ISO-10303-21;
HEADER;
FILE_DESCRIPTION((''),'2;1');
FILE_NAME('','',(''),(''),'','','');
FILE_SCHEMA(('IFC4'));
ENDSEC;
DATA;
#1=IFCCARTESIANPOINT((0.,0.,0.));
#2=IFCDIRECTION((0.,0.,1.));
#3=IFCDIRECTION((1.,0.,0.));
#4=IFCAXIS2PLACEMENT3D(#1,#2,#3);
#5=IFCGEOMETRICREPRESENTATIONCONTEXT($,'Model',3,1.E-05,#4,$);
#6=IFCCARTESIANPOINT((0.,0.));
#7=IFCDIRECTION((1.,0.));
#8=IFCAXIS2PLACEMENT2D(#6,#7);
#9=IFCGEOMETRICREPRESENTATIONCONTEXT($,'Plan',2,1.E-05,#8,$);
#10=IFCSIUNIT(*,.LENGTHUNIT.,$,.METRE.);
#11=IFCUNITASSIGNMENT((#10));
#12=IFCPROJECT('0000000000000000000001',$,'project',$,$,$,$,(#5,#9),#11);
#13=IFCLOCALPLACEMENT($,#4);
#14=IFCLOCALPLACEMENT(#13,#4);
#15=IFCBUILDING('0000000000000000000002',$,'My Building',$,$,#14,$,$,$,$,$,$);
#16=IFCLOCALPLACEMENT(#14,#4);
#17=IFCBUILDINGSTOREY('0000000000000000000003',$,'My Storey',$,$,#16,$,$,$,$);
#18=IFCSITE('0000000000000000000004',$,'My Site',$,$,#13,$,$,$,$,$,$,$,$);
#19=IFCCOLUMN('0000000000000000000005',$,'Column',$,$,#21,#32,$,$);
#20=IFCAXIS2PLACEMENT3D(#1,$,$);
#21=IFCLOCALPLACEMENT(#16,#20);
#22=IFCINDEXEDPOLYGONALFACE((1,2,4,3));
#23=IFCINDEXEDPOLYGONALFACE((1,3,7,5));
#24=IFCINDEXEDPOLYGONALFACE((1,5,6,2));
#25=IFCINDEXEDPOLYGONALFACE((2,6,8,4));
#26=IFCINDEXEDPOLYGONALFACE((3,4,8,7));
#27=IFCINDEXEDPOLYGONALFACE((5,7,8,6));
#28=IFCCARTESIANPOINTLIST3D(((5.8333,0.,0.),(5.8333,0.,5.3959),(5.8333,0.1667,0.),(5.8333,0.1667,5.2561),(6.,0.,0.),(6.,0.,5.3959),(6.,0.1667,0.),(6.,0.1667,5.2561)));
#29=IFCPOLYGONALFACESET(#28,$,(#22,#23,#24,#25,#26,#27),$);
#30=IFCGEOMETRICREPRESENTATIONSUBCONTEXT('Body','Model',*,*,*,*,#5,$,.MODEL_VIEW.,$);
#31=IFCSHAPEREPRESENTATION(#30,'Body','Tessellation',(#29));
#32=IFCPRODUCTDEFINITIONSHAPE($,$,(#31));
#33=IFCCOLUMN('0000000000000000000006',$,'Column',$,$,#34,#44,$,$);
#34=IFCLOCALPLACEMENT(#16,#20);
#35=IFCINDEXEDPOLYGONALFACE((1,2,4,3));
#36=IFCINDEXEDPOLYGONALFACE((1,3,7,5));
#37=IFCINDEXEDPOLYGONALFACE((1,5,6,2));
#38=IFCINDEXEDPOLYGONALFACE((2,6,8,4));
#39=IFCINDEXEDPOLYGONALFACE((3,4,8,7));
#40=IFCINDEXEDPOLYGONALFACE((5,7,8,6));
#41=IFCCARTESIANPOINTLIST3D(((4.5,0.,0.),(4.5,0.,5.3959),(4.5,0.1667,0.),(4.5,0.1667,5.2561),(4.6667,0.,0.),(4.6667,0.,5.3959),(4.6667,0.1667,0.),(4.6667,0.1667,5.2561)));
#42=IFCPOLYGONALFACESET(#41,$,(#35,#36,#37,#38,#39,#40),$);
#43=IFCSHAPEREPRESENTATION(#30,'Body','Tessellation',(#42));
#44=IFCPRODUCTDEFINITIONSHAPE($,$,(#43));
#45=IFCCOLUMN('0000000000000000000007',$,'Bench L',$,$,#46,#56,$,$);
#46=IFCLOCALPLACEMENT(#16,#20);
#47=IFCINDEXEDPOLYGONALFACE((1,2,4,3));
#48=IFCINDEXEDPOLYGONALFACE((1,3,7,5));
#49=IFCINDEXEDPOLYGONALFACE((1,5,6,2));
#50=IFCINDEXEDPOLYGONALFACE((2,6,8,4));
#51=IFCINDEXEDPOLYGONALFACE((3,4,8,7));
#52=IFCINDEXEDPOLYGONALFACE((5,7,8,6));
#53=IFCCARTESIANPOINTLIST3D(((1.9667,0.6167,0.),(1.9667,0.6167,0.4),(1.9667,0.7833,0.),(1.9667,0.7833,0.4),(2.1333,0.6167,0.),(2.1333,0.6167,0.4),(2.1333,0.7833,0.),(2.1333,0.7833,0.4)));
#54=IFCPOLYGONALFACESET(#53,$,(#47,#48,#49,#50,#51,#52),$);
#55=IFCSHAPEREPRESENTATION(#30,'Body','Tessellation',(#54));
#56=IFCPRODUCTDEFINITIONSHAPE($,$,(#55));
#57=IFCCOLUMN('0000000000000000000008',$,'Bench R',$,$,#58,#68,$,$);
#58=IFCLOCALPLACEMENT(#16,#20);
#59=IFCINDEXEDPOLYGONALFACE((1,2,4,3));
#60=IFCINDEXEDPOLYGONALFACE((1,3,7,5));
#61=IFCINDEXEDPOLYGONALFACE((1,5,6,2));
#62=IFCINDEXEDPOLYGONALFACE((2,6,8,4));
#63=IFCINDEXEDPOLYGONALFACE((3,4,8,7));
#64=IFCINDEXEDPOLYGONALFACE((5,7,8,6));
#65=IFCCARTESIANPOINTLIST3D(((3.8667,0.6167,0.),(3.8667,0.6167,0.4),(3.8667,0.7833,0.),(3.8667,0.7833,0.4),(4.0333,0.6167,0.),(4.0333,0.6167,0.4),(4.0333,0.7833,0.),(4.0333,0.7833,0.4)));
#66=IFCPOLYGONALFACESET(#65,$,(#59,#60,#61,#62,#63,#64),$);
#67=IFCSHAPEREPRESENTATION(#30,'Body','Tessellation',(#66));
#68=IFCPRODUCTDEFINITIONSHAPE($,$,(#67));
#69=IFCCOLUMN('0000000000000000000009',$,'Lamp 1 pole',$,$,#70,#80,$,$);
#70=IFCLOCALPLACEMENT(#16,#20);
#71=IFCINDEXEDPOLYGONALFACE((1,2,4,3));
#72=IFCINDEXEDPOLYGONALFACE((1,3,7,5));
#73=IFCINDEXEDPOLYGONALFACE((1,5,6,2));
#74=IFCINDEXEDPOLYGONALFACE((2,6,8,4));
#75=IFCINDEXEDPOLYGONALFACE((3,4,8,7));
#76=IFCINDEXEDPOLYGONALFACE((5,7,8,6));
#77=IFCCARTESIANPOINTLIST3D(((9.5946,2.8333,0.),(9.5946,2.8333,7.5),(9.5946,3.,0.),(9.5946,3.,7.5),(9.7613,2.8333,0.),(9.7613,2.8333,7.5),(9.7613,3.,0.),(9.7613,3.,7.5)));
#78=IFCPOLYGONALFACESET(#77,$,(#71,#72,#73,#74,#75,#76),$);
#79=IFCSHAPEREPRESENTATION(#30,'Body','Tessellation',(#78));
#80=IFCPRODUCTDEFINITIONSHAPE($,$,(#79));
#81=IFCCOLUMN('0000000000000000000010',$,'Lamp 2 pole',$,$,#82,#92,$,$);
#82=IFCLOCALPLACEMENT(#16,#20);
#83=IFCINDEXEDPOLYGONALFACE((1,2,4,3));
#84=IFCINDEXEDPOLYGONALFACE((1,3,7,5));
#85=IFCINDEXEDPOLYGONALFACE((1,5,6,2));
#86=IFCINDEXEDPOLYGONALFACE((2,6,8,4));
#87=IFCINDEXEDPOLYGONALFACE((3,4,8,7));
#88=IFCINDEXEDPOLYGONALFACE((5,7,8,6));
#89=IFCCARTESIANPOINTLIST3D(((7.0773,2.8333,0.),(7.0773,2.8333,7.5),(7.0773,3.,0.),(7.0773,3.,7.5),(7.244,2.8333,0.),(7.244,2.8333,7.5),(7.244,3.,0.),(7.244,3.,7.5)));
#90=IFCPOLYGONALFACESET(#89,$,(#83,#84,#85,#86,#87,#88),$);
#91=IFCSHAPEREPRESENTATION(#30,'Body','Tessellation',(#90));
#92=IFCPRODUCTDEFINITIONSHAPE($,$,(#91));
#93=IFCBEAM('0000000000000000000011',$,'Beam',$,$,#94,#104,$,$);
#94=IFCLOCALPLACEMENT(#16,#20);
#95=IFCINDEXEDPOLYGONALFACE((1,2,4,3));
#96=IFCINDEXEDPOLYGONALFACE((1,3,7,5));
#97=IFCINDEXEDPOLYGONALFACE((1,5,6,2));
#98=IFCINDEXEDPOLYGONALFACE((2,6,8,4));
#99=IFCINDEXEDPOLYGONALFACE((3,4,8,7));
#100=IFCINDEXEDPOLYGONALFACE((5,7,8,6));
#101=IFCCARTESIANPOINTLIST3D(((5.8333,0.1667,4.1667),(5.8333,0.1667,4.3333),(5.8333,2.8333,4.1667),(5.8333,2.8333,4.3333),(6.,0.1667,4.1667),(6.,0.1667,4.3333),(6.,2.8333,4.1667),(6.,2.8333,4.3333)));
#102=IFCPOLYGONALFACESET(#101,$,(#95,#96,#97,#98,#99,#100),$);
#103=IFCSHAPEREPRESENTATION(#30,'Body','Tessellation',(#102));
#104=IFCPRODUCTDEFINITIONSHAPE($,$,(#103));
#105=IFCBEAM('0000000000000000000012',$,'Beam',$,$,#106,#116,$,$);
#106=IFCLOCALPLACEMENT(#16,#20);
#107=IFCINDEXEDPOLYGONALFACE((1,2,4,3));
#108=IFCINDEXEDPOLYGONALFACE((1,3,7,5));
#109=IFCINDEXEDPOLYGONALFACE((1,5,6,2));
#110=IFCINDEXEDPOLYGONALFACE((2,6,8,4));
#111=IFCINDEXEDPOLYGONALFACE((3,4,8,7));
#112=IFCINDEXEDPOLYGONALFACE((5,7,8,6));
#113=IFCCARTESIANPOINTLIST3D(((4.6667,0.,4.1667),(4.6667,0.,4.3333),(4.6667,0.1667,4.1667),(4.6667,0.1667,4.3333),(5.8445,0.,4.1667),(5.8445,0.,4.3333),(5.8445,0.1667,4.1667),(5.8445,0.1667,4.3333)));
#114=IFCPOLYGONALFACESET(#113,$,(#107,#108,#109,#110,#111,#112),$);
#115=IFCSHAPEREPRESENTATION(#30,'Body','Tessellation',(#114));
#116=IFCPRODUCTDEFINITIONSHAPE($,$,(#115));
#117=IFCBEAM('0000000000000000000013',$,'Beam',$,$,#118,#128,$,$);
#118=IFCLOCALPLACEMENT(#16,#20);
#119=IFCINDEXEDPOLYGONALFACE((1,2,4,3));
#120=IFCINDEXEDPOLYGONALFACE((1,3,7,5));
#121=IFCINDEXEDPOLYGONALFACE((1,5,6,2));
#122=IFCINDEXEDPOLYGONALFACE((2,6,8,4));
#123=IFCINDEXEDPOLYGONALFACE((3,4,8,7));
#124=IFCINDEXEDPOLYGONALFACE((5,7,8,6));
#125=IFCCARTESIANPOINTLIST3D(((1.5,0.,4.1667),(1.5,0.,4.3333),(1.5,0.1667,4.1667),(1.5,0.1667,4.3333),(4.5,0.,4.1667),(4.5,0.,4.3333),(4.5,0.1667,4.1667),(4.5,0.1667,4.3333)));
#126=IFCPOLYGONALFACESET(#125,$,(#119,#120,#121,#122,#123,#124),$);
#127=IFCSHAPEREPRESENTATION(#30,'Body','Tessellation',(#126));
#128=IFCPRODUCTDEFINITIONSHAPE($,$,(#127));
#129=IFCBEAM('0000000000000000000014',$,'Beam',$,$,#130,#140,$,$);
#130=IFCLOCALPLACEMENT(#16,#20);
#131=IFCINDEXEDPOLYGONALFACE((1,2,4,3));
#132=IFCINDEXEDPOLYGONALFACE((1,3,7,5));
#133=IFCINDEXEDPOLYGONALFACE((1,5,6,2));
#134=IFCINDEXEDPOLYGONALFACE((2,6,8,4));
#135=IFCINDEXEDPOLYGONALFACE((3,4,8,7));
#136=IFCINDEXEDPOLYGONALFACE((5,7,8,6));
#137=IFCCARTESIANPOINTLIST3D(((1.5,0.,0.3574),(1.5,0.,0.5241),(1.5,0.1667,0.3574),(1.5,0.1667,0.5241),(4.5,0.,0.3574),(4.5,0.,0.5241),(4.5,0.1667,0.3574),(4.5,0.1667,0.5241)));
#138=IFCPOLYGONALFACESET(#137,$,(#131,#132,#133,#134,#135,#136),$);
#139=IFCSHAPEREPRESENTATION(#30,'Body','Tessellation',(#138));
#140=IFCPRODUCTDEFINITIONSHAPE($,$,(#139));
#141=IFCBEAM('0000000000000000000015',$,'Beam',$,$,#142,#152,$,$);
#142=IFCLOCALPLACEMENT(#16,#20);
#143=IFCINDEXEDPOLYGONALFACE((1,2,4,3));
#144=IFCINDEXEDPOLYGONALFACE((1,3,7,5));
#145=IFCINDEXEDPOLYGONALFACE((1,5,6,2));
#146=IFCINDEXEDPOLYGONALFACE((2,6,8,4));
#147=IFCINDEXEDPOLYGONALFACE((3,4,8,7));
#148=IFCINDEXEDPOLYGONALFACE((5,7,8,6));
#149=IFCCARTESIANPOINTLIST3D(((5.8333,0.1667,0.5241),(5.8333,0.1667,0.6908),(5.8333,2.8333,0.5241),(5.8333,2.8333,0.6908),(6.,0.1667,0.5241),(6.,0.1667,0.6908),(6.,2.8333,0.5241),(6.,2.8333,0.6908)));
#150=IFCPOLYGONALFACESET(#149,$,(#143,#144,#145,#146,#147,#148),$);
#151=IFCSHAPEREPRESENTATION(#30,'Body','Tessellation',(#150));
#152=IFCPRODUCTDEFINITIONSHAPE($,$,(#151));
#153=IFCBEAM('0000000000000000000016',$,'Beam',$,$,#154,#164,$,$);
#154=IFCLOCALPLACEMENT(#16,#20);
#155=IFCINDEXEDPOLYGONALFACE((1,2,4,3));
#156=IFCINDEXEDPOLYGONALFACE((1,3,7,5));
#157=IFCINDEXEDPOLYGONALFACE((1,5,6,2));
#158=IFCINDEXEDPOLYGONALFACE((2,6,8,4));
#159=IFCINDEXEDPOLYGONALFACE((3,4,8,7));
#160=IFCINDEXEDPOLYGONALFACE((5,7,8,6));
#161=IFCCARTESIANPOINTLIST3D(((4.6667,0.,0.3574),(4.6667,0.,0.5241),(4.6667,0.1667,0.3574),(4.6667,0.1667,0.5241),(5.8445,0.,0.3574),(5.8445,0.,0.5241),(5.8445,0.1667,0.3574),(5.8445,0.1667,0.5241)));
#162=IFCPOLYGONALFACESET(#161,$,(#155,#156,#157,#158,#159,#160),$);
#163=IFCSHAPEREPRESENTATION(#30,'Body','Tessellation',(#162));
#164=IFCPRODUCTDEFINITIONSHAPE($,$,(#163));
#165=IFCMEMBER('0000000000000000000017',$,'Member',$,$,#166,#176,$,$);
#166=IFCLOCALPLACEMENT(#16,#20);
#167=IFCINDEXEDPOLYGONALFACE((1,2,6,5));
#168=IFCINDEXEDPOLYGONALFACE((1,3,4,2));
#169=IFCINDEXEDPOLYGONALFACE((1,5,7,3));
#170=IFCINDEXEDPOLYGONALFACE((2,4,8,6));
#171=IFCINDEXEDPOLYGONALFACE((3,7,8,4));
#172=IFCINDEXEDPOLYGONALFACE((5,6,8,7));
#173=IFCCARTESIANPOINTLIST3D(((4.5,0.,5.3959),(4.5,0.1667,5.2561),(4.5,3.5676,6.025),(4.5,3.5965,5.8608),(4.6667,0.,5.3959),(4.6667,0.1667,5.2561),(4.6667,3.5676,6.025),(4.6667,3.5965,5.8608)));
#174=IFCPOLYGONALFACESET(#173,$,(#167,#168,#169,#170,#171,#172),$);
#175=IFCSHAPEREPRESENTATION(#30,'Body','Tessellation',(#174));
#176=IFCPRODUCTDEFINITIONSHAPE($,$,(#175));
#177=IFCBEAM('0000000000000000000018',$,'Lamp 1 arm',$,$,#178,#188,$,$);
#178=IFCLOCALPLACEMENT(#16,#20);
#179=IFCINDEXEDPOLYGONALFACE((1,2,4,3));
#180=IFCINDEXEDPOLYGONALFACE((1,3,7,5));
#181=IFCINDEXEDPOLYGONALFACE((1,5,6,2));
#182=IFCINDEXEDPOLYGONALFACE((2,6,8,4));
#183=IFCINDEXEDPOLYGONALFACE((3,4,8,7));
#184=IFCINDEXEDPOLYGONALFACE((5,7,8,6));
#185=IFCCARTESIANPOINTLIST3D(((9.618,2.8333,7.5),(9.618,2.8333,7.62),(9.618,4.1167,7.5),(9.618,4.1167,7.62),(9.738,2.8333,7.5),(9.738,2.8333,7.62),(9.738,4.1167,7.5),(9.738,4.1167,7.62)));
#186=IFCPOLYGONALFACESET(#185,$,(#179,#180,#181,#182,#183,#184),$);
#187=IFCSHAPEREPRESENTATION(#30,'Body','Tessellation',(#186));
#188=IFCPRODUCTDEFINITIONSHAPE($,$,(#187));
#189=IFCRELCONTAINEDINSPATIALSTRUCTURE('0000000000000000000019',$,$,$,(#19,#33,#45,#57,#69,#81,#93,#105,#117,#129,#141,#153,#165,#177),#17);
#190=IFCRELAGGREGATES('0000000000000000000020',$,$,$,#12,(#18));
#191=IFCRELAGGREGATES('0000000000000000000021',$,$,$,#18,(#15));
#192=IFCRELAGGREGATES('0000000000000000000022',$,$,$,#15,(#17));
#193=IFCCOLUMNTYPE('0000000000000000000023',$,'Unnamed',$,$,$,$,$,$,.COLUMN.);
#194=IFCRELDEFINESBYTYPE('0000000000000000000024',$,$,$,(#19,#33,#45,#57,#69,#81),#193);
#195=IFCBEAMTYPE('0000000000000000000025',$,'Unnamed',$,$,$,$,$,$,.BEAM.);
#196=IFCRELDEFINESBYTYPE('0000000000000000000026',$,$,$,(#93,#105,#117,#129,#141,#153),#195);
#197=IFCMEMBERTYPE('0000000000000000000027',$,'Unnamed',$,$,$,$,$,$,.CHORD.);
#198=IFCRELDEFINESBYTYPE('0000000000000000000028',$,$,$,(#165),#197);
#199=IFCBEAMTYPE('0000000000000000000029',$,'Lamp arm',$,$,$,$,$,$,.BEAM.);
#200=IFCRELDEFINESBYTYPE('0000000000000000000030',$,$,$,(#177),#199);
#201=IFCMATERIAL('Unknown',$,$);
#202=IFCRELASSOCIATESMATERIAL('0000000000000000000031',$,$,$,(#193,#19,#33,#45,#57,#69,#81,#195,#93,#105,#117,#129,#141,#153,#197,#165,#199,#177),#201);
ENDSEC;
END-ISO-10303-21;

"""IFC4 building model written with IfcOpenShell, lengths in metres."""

from ifc_helpers import new_model, si_unit, frame, origin_with_axes, origin_2d_with_axis, place, context, subcontext, project, spatial, rectangle, extrude, clip, halfspace, material, material_profile, profile_set, profile_usage, type_object, element, save


model = new_model("IFC4")

# Units and contexts
model_context = context("Model", 3, precision=1e-05, world=origin_with_axes())
plan_context = context("Plan", 2, precision=1e-05, world=origin_2d_with_axis())
body_context = subcontext(model_context, "Body", "Model", "MODEL_VIEW")
ifc_project = project(units=[si_unit("LENGTHUNIT", "METRE")], contexts=[model_context, plan_context])

# Site, building, storey
site_placement = place(None, origin_with_axes())
site = spatial("IfcSite", under=ifc_project, at=site_placement, Name="My Site")
building_placement = place(site_placement, origin_with_axes())
building = spatial("IfcBuilding", under=site, at=building_placement, Name="My Building")
storey_placement = place(building_placement, origin_with_axes())
storey = spatial("IfcBuildingStorey", under=building, at=storey_placement, Name="My Storey")

# Columns
ifc_material = material(Name="Unknown")
ifc_material_profile_1 = material_profile(ifc_material, rectangle(XDim=0.1667, YDim=0.1667))
ifc_profile_set_1 = profile_set([ifc_material_profile_1])
column_type = type_object("IfcColumnType", Name="Unnamed", PredefinedType="COLUMN", material=ifc_profile_set_1)
ifc_profile_usage_1 = profile_usage(ifc_profile_set_1, cardinal=5)
column_1_placement = place(storey_placement, frame((5.9167, 0.0833, 0.0), z_axis=(0.0, 0.0, 1.0), x_axis=(1.0, 0.0, 0.0)))
element("IfcColumn", 1, at=column_1_placement, inside=storey, type_object=column_type, material=ifc_profile_usage_1, Name="Column", context=body_context, shape_type="Clipping", body=[
    clip(extrude(rectangle(XDim=0.1667, YDim=0.1667), origin_with_axes(), (0.0, 0.0, 1.0), 5.5773), halfspace(frame((-5.9167, -0.0833, 5.3959), z_axis=(0.0, 0.642787, 0.766045), x_axis=(1.0, 0.0, 0.0)), False)),
])
ifc_profile_usage_2 = profile_usage(ifc_profile_set_1, cardinal=5)
column_2_placement = place(storey_placement, frame((4.5833, 0.0833, 0.0), z_axis=(0.0, 0.0, 1.0), x_axis=(1.0, 0.0, 0.0)))
element("IfcColumn", 2, at=column_2_placement, inside=storey, type_object=column_type, material=ifc_profile_usage_2, Name="Column", context=body_context, shape_type="Clipping", body=[
    clip(extrude(rectangle(XDim=0.1667, YDim=0.1667), origin_with_axes(), (0.0, 0.0, 1.0), 5.5773), halfspace(frame((-4.5833, -0.0833, 5.3959), z_axis=(0.0, 0.642786, 0.766046), x_axis=(1.0, 0.0, 0.0)), False)),
])
ifc_profile_usage_3 = profile_usage(ifc_profile_set_1, cardinal=5)
column_3_placement = place(storey_placement, frame((2.05, 0.7, 0.0), z_axis=(0.0, 0.0, 1.0), x_axis=(1.0, 0.0, 0.0)))
element("IfcColumn", 3, at=column_3_placement, inside=storey, type_object=column_type, material=ifc_profile_usage_3, Name="Bench L", context=body_context, shape_type="SweptSolid", body=[
    extrude(rectangle(XDim=0.1667, YDim=0.1667), origin_with_axes(), (0.0, 0.0, 1.0), 0.4),
])
ifc_profile_usage_4 = profile_usage(ifc_profile_set_1, cardinal=5)
column_4_placement = place(storey_placement, frame((3.95, 0.7, 0.0), z_axis=(0.0, 0.0, 1.0), x_axis=(1.0, 0.0, 0.0)))
element("IfcColumn", 4, at=column_4_placement, inside=storey, type_object=column_type, material=ifc_profile_usage_4, Name="Bench R", context=body_context, shape_type="SweptSolid", body=[
    extrude(rectangle(XDim=0.1667, YDim=0.1667), origin_with_axes(), (0.0, 0.0, 1.0), 0.4),
])
ifc_profile_usage_5 = profile_usage(ifc_profile_set_1, cardinal=5)
column_5_placement = place(storey_placement, frame((9.678, 2.9167, 0.0), z_axis=(0.0, 0.0, 1.0), x_axis=(1.0, 0.0, 0.0)))
element("IfcColumn", 5, at=column_5_placement, inside=storey, type_object=column_type, material=ifc_profile_usage_5, Name="Lamp 1 pole", context=body_context, shape_type="SweptSolid", body=[
    extrude(rectangle(XDim=0.1667, YDim=0.1667), origin_with_axes(), (0.0, 0.0, 1.0), 7.5),
])
ifc_profile_usage_6 = profile_usage(ifc_profile_set_1, cardinal=5)
column_6_placement = place(storey_placement, frame((7.1606, 2.9167, 0.0), z_axis=(0.0, 0.0, 1.0), x_axis=(1.0, 0.0, 0.0)))
element("IfcColumn", 6, at=column_6_placement, inside=storey, type_object=column_type, material=ifc_profile_usage_6, Name="Lamp 2 pole", context=body_context, shape_type="SweptSolid", body=[
    extrude(rectangle(XDim=0.1667, YDim=0.1667), origin_with_axes(), (0.0, 0.0, 1.0), 7.5),
])

# Beams
ifc_material_profile_2 = material_profile(ifc_material, rectangle(XDim=0.1667, YDim=0.1667))
ifc_profile_set_2 = profile_set([ifc_material_profile_2])
ifc_profile_usage_7 = profile_usage(ifc_profile_set_2, cardinal=5)
beam_type_1 = type_object("IfcBeamType", Name="Unnamed", PredefinedType="BEAM", material=ifc_profile_set_2)
beam_1_placement = place(storey_placement, frame((5.9167, 2.8333, 4.25), z_axis=(0.0, -1.0, 0.0), x_axis=(1.0, 0.0, 0.0)))
element("IfcBeam", 7, at=beam_1_placement, inside=storey, type_object=beam_type_1, material=ifc_profile_usage_7, Name="Beam", context=body_context, shape_type="SweptSolid", body=[
    extrude(rectangle(XDim=0.1667, YDim=0.1667), origin_with_axes(), (0.0, 0.0, 1.0), 2.6667),
])
ifc_profile_usage_8 = profile_usage(ifc_profile_set_2, cardinal=5)
beam_2_placement = place(storey_placement, frame((5.8445, 0.0833, 4.25), z_axis=(-1.0, -0.000001, 0.0), x_axis=(0.000001, -1.0, 0.0)))
element("IfcBeam", 8, at=beam_2_placement, inside=storey, type_object=beam_type_1, material=ifc_profile_usage_8, Name="Beam", context=body_context, shape_type="SweptSolid", body=[
    extrude(rectangle(XDim=0.1667, YDim=0.1667), origin_with_axes(), (0.0, 0.0, 1.0), 1.1778),
])
ifc_profile_usage_9 = profile_usage(ifc_profile_set_2, cardinal=5)
beam_3_placement = place(storey_placement, frame((4.5, 0.0833, 4.25), z_axis=(-1.0, -0.000001, 0.000001), x_axis=(0.000001, -1.0, 0.0)))
element("IfcBeam", 9, at=beam_3_placement, inside=storey, type_object=beam_type_1, material=ifc_profile_usage_9, Name="Beam", context=body_context, shape_type="SweptSolid", body=[
    extrude(rectangle(XDim=0.1667, YDim=0.1667), origin_with_axes(), (0.0, 0.0, 1.0), 3.0),
])
ifc_profile_usage_10 = profile_usage(ifc_profile_set_2, cardinal=5)
beam_4_placement = place(storey_placement, frame((4.5, 0.0833, 0.4408), z_axis=(-1.0, -0.000001, 0.000001), x_axis=(0.000001, -1.0, 0.0)))
element("IfcBeam", 10, at=beam_4_placement, inside=storey, type_object=beam_type_1, material=ifc_profile_usage_10, Name="Beam", context=body_context, shape_type="SweptSolid", body=[
    extrude(rectangle(XDim=0.1667, YDim=0.1667), origin_with_axes(), (0.0, 0.0, 1.0), 3.0),
])
ifc_profile_usage_11 = profile_usage(ifc_profile_set_2, cardinal=5)
beam_5_placement = place(storey_placement, frame((5.9167, 2.8333, 0.6074), z_axis=(0.0, -1.0, 0.0), x_axis=(1.0, 0.0, 0.0)))
element("IfcBeam", 11, at=beam_5_placement, inside=storey, type_object=beam_type_1, material=ifc_profile_usage_11, Name="Beam", context=body_context, shape_type="SweptSolid", body=[
    extrude(rectangle(XDim=0.1667, YDim=0.1667), origin_with_axes(), (0.0, 0.0, 1.0), 2.6667),
])
ifc_profile_usage_12 = profile_usage(ifc_profile_set_2, cardinal=5)
beam_6_placement = place(storey_placement, frame((5.8445, 0.0833, 0.4408), z_axis=(-1.0, -0.000001, 0.0), x_axis=(0.000001, -1.0, 0.0)))
element("IfcBeam", 12, at=beam_6_placement, inside=storey, type_object=beam_type_1, material=ifc_profile_usage_12, Name="Beam", context=body_context, shape_type="SweptSolid", body=[
    extrude(rectangle(XDim=0.1667, YDim=0.1667), origin_with_axes(), (0.0, 0.0, 1.0), 1.1778),
])

# Member
ifc_material_profile_3 = material_profile(ifc_material, rectangle(XDim=0.1667, YDim=0.1667))
ifc_profile_set_3 = profile_set([ifc_material_profile_3])
ifc_profile_usage_13 = profile_usage(ifc_profile_set_3, cardinal=5)
member_type = type_object("IfcMemberType", Name="Unnamed", PredefinedType="CHORD", material=ifc_profile_set_3)
member_1_placement = place(storey_placement, frame((4.5833, -0.1641, 5.2823), z_axis=(0.0, 0.984808, 0.173648), x_axis=(-1.0, 0.0, 0.0)))
element("IfcMember", 13, at=member_1_placement, inside=storey, type_object=member_type, material=ifc_profile_usage_13, Name="Member", context=body_context, shape_type="Clipping", body=[
    clip(extrude(rectangle(XDim=0.1667, YDim=0.1667), origin_with_axes(), (0.0, 0.0, 1.0), 3.8039), halfspace(frame((4.5833, 0.0833, 0.1814), z_axis=(0.0, -0.642788, -0.766045), x_axis=(-1.0, 0.0, 0.0)), False)),
])

# Beam
ifc_material_profile_4 = material_profile(ifc_material, rectangle(XDim=0.12, YDim=0.12))
ifc_profile_set_4 = profile_set([ifc_material_profile_4])
ifc_profile_usage_14 = profile_usage(ifc_profile_set_4, cardinal=5)
beam_type_2 = type_object("IfcBeamType", Name="Lamp arm", PredefinedType="BEAM", material=ifc_profile_set_4)
beam_7_placement = place(storey_placement, frame((9.678, 2.8333, 7.56), z_axis=(0.0, 1.0, 0.0), x_axis=(1.0, 0.0, 0.0)))
element("IfcBeam", 14, at=beam_7_placement, inside=storey, type_object=beam_type_2, material=ifc_profile_usage_14, Name="Lamp 1 arm", context=body_context, shape_type="SweptSolid", body=[
    extrude(rectangle(XDim=0.12, YDim=0.12), origin_with_axes(), (0.0, 0.0, 1.0), 1.2833),
])

save(model, "model.ifc")
